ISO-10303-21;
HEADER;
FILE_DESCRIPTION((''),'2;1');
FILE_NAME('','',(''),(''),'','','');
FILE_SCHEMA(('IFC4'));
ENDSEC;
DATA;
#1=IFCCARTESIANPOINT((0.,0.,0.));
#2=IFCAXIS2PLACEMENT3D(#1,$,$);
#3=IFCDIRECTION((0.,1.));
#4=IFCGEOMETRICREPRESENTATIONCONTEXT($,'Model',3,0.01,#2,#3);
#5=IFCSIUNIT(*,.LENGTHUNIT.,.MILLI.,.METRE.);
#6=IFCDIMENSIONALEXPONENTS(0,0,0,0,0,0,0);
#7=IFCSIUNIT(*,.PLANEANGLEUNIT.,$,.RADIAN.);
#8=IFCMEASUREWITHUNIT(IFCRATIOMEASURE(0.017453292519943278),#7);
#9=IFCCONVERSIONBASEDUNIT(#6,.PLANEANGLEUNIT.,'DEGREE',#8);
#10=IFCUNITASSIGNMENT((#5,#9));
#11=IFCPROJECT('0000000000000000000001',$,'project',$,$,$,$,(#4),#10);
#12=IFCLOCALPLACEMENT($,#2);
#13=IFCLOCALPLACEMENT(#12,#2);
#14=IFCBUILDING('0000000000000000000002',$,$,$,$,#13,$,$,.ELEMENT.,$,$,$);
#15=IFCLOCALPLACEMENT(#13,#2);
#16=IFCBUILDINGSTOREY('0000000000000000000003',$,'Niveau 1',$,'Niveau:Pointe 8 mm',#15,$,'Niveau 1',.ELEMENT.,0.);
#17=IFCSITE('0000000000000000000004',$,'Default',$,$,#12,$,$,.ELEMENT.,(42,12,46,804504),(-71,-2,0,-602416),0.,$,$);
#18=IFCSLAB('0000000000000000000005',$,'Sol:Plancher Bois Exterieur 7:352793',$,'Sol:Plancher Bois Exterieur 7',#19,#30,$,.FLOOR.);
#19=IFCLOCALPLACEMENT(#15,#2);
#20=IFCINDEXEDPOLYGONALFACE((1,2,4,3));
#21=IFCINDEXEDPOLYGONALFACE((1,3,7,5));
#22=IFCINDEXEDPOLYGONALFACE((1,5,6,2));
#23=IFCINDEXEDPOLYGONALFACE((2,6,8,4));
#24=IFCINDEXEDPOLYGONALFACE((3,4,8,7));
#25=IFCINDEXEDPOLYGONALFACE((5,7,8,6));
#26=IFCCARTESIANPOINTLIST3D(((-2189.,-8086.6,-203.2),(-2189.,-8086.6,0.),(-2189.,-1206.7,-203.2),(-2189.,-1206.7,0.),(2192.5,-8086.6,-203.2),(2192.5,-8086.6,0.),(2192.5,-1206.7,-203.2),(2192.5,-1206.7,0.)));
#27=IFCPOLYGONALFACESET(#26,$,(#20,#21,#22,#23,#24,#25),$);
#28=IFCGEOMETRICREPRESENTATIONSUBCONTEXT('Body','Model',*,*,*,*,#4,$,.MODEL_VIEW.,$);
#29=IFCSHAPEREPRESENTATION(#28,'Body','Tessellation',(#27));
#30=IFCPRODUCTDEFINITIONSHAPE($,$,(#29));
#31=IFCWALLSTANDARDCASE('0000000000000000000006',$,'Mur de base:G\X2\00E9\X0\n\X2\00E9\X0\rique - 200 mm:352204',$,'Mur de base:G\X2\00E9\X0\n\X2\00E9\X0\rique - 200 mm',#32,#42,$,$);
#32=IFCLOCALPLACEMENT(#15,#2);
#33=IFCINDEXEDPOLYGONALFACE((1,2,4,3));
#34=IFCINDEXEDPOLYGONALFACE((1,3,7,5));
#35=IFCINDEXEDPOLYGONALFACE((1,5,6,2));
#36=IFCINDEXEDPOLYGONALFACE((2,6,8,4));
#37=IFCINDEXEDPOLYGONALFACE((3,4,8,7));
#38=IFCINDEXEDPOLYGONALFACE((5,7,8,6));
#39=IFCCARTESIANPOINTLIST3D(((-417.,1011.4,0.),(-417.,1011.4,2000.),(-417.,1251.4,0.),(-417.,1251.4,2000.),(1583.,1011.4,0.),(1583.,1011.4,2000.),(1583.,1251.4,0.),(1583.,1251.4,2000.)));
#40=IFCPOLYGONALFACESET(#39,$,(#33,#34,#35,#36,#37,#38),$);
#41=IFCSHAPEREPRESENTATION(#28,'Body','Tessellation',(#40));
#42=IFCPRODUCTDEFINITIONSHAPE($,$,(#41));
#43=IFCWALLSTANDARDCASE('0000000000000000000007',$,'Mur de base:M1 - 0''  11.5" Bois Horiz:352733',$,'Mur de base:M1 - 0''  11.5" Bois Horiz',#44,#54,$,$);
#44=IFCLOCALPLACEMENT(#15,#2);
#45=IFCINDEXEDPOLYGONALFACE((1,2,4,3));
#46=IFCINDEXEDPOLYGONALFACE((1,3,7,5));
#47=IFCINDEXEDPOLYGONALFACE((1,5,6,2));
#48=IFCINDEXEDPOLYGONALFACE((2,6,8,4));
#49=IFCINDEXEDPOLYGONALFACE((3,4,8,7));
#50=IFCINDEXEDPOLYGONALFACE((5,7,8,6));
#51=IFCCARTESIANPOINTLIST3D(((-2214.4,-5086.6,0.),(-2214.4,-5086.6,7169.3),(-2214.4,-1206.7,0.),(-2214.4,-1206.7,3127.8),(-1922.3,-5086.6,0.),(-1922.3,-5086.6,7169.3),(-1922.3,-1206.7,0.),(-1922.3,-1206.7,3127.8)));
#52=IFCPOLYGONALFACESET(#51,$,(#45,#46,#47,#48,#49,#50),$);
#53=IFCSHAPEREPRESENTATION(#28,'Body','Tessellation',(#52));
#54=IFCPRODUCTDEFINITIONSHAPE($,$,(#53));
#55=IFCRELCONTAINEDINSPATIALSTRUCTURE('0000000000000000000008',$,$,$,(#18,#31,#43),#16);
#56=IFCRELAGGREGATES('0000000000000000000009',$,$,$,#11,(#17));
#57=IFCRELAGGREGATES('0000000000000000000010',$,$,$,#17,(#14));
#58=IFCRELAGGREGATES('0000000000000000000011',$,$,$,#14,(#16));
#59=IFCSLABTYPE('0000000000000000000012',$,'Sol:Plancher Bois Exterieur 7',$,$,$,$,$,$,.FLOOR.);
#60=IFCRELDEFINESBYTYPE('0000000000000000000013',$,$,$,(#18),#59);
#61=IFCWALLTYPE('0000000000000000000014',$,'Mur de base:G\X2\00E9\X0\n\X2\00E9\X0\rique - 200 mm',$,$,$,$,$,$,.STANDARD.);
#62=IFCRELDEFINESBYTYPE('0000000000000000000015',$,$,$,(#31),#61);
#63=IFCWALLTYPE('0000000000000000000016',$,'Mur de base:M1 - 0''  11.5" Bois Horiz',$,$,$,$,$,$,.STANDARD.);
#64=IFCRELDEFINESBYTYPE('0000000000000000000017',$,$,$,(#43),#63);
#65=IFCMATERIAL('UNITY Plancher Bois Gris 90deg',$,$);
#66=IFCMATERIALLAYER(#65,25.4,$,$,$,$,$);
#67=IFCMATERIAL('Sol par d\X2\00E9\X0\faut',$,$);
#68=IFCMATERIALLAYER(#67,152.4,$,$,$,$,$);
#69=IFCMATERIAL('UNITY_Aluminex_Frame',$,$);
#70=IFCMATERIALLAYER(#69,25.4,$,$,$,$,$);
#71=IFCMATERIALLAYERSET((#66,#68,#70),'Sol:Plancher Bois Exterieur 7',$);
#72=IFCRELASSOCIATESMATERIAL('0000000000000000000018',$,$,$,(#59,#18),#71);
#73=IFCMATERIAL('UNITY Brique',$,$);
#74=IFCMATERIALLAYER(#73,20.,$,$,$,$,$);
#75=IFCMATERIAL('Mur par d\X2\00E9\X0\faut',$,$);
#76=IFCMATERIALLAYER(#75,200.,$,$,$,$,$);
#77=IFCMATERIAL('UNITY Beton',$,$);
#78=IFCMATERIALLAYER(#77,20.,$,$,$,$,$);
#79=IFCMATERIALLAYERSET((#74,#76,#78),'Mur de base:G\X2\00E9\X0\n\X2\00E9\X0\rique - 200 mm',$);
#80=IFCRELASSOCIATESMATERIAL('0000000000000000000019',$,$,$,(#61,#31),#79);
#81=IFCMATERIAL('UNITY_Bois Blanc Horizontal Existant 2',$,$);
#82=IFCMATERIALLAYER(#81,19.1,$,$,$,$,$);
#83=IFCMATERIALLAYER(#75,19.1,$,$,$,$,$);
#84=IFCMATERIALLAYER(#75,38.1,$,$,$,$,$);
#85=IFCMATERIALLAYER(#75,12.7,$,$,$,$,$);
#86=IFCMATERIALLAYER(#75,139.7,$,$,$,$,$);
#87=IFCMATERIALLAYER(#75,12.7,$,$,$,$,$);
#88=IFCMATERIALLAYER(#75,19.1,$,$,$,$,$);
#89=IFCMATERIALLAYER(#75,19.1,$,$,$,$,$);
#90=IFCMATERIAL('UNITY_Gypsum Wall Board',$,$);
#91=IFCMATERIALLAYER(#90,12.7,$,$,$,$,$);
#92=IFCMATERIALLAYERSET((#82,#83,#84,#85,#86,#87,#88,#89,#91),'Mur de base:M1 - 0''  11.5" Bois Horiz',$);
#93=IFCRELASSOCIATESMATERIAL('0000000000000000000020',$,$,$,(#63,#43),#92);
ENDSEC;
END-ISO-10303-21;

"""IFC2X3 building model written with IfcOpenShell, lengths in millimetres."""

from ifc_helpers import new_model, entity, si_unit, converted_unit, direction, frame, frame_2d, origin, place, context, subcontext, project, spatial, polyline, rectangle, extrude, clip, bounded_halfspace, material, layer, layer_set, layer_usage, type_object, element, save


model = new_model("IFC2X3")

# Units and contexts
model_context = context("Model", 3, precision=0.01, world=origin(), true_north=direction((0.0, 1.0)))
body_context = subcontext(model_context, "Body", "Model", "MODEL_VIEW")
ifc_project = project(units=[si_unit("LENGTHUNIT", "METRE", prefix="MILLI"), converted_unit("PLANEANGLEUNIT", "DEGREE", entity("IfcRatioMeasure", 0.017453292519943278), si_unit("PLANEANGLEUNIT", "RADIAN"), dimensions=[0, 0, 0, 0, 0, 0, 0])], contexts=[model_context])

# Site, building, storey
site_placement = place(None, origin())
site = spatial("IfcSite", under=ifc_project, at=site_placement, Name="Default", CompositionType="ELEMENT", RefLatitude=(42, 12, 46, 804504), RefLongitude=(-71, -2, 0, -602416), RefElevation=0.0)
building_placement = place(site_placement, origin())
building = spatial("IfcBuilding", under=site, at=building_placement, CompositionType="ELEMENT")
storey_placement = place(building_placement, origin())
storey = spatial("IfcBuildingStorey", under=building, at=storey_placement, Name="Niveau 1", ObjectType="Niveau:Pointe 8 mm", LongName="Niveau 1", CompositionType="ELEMENT", Elevation=0.0)

# Slab
ifc_material_1 = material(Name="UNITY Plancher Bois Gris 90deg")
ifc_layer_1 = layer(ifc_material_1, 25.4)
ifc_material_2 = material(Name="Sol par défaut")
ifc_layer_2 = layer(ifc_material_2, 152.4)
ifc_material_3 = material(Name="UNITY_Aluminex_Frame")
ifc_layer_3 = layer(ifc_material_3, 25.4)
ifc_layer_set_1 = layer_set([ifc_layer_1, ifc_layer_2, ifc_layer_3], Name="Sol:Plancher Bois Exterieur 7")
ifc_layer_usage_1 = layer_usage(ifc_layer_set_1, "AXIS3", "POSITIVE", 0.0)
slab_type = type_object("IfcSlabType", Name="Sol:Plancher Bois Exterieur 7", PredefinedType="FLOOR", material=ifc_layer_set_1)
slab_placement = place(storey_placement, origin())
element("IfcSlab", 1, at=slab_placement, inside=storey, type_object=slab_type, material=ifc_layer_usage_1, Name="Sol:Plancher Bois Exterieur 7:352793", ObjectType="Sol:Plancher Bois Exterieur 7", PredefinedType="FLOOR", context=body_context, shape_type="SweptSolid", body=[
    extrude(rectangle(XDim=6879.8, YDim=4381.5, at=frame_2d((0.0, 0.0), x_axis=(1.0, 0.0))), frame((1.8, -4646.6, 0.0), z_axis=(0.0, 0.0, -1.0), x_axis=(0.0, 1.0, 0.0)), (0.0, 0.0, 1.0), 203.2),
])

# Wall
ifc_material_4 = material(Name="UNITY Brique")
ifc_layer_4 = layer(ifc_material_4, 20.0)
ifc_material_5 = material(Name="Mur par défaut")
ifc_layer_5 = layer(ifc_material_5, 200.0)
ifc_material_6 = material(Name="UNITY Beton")
ifc_layer_6 = layer(ifc_material_6, 20.0)
ifc_layer_set_2 = layer_set([ifc_layer_4, ifc_layer_5, ifc_layer_6], Name="Mur de base:Générique - 200 mm")
ifc_layer_usage_2 = layer_usage(ifc_layer_set_2, "AXIS2", "NEGATIVE", 120.0)
wall_type_1 = type_object("IfcWallType", Name="Mur de base:Générique - 200 mm", PredefinedType="STANDARD", material=ifc_layer_set_2)
wall_1_placement = place(storey_placement, frame((-417.0, 1131.4, 0.0)))
element("IfcWallStandardCase", 2, at=wall_1_placement, inside=storey, type_object=wall_type_1, material=ifc_layer_usage_2, Name="Mur de base:Générique - 200 mm:352204", ObjectType="Mur de base:Générique - 200 mm", context=body_context, shape_type="SweptSolid", body=[
    extrude(rectangle(XDim=2000.0, YDim=240.0, at=frame_2d((1000.0, 0.0), x_axis=(-1.0, 0.0))), origin(), (0.0, 0.0, 1.0), 2000.0),
])

# Shared definitions
ifc_material_7 = material(Name="UNITY_Bois Blanc Horizontal Existant 2")
ifc_layer_7 = layer(ifc_material_7, 19.1)
ifc_layer_8 = layer(ifc_material_5, 19.1)
ifc_layer_9 = layer(ifc_material_5, 38.1)
ifc_layer_10 = layer(ifc_material_5, 12.7)
ifc_layer_11 = layer(ifc_material_5, 139.7)
ifc_layer_12 = layer(ifc_material_5, 12.7)
ifc_layer_13 = layer(ifc_material_5, 19.1)
ifc_layer_14 = layer(ifc_material_5, 19.1)
ifc_material_8 = material(Name="UNITY_Gypsum Wall Board")
ifc_layer_15 = layer(ifc_material_8, 12.7)
ifc_layer_set_3 = layer_set([ifc_layer_7, ifc_layer_8, ifc_layer_9, ifc_layer_10, ifc_layer_11, ifc_layer_12, ifc_layer_13, ifc_layer_14, ifc_layer_15], Name="Mur de base:M1 - 0'  11.5\" Bois Horiz")
wall_type_2 = type_object("IfcWallType", Name="Mur de base:M1 - 0'  11.5\" Bois Horiz", PredefinedType="STANDARD", material=ifc_layer_set_3)

# Wall
ifc_layer_usage_3 = layer_usage(ifc_layer_set_3, "AXIS2", "NEGATIVE", 146.1)
wall_2_placement = place(storey_placement, frame((-2068.3, -5086.6, 0.0), z_axis=(0.0, 0.0, 1.0), x_axis=(0.0, 1.0, 0.0)))
element("IfcWallStandardCase", 3, at=wall_2_placement, inside=storey, type_object=wall_type_2, material=ifc_layer_usage_3, Name="Mur de base:M1 - 0'  11.5\" Bois Horiz:352733", ObjectType="Mur de base:M1 - 0'  11.5\" Bois Horiz", context=body_context, shape_type="Clipping", body=[
    clip(extrude(rectangle(XDim=3879.8, YDim=292.1, at=frame_2d((1939.9, 0.0), x_axis=(-1.0, 0.0))), origin(), (0.0, 0.0, 1.0), 7169.3), bounded_halfspace(frame((0.0, -146.0, 7169.3), z_axis=(0.721387, 0.0, 0.692532), x_axis=(0.0, 1.0, 0.0)), False, frame((0.0, -146.0, 7169.3)), polyline([(0.0, 0.0), (292.1, 0.0), (3879.8, 0.0), (3879.8, 292.1), (0.0, 292.1), (0.0, 0.0)]))),
])

save(model, "model.ifc")
